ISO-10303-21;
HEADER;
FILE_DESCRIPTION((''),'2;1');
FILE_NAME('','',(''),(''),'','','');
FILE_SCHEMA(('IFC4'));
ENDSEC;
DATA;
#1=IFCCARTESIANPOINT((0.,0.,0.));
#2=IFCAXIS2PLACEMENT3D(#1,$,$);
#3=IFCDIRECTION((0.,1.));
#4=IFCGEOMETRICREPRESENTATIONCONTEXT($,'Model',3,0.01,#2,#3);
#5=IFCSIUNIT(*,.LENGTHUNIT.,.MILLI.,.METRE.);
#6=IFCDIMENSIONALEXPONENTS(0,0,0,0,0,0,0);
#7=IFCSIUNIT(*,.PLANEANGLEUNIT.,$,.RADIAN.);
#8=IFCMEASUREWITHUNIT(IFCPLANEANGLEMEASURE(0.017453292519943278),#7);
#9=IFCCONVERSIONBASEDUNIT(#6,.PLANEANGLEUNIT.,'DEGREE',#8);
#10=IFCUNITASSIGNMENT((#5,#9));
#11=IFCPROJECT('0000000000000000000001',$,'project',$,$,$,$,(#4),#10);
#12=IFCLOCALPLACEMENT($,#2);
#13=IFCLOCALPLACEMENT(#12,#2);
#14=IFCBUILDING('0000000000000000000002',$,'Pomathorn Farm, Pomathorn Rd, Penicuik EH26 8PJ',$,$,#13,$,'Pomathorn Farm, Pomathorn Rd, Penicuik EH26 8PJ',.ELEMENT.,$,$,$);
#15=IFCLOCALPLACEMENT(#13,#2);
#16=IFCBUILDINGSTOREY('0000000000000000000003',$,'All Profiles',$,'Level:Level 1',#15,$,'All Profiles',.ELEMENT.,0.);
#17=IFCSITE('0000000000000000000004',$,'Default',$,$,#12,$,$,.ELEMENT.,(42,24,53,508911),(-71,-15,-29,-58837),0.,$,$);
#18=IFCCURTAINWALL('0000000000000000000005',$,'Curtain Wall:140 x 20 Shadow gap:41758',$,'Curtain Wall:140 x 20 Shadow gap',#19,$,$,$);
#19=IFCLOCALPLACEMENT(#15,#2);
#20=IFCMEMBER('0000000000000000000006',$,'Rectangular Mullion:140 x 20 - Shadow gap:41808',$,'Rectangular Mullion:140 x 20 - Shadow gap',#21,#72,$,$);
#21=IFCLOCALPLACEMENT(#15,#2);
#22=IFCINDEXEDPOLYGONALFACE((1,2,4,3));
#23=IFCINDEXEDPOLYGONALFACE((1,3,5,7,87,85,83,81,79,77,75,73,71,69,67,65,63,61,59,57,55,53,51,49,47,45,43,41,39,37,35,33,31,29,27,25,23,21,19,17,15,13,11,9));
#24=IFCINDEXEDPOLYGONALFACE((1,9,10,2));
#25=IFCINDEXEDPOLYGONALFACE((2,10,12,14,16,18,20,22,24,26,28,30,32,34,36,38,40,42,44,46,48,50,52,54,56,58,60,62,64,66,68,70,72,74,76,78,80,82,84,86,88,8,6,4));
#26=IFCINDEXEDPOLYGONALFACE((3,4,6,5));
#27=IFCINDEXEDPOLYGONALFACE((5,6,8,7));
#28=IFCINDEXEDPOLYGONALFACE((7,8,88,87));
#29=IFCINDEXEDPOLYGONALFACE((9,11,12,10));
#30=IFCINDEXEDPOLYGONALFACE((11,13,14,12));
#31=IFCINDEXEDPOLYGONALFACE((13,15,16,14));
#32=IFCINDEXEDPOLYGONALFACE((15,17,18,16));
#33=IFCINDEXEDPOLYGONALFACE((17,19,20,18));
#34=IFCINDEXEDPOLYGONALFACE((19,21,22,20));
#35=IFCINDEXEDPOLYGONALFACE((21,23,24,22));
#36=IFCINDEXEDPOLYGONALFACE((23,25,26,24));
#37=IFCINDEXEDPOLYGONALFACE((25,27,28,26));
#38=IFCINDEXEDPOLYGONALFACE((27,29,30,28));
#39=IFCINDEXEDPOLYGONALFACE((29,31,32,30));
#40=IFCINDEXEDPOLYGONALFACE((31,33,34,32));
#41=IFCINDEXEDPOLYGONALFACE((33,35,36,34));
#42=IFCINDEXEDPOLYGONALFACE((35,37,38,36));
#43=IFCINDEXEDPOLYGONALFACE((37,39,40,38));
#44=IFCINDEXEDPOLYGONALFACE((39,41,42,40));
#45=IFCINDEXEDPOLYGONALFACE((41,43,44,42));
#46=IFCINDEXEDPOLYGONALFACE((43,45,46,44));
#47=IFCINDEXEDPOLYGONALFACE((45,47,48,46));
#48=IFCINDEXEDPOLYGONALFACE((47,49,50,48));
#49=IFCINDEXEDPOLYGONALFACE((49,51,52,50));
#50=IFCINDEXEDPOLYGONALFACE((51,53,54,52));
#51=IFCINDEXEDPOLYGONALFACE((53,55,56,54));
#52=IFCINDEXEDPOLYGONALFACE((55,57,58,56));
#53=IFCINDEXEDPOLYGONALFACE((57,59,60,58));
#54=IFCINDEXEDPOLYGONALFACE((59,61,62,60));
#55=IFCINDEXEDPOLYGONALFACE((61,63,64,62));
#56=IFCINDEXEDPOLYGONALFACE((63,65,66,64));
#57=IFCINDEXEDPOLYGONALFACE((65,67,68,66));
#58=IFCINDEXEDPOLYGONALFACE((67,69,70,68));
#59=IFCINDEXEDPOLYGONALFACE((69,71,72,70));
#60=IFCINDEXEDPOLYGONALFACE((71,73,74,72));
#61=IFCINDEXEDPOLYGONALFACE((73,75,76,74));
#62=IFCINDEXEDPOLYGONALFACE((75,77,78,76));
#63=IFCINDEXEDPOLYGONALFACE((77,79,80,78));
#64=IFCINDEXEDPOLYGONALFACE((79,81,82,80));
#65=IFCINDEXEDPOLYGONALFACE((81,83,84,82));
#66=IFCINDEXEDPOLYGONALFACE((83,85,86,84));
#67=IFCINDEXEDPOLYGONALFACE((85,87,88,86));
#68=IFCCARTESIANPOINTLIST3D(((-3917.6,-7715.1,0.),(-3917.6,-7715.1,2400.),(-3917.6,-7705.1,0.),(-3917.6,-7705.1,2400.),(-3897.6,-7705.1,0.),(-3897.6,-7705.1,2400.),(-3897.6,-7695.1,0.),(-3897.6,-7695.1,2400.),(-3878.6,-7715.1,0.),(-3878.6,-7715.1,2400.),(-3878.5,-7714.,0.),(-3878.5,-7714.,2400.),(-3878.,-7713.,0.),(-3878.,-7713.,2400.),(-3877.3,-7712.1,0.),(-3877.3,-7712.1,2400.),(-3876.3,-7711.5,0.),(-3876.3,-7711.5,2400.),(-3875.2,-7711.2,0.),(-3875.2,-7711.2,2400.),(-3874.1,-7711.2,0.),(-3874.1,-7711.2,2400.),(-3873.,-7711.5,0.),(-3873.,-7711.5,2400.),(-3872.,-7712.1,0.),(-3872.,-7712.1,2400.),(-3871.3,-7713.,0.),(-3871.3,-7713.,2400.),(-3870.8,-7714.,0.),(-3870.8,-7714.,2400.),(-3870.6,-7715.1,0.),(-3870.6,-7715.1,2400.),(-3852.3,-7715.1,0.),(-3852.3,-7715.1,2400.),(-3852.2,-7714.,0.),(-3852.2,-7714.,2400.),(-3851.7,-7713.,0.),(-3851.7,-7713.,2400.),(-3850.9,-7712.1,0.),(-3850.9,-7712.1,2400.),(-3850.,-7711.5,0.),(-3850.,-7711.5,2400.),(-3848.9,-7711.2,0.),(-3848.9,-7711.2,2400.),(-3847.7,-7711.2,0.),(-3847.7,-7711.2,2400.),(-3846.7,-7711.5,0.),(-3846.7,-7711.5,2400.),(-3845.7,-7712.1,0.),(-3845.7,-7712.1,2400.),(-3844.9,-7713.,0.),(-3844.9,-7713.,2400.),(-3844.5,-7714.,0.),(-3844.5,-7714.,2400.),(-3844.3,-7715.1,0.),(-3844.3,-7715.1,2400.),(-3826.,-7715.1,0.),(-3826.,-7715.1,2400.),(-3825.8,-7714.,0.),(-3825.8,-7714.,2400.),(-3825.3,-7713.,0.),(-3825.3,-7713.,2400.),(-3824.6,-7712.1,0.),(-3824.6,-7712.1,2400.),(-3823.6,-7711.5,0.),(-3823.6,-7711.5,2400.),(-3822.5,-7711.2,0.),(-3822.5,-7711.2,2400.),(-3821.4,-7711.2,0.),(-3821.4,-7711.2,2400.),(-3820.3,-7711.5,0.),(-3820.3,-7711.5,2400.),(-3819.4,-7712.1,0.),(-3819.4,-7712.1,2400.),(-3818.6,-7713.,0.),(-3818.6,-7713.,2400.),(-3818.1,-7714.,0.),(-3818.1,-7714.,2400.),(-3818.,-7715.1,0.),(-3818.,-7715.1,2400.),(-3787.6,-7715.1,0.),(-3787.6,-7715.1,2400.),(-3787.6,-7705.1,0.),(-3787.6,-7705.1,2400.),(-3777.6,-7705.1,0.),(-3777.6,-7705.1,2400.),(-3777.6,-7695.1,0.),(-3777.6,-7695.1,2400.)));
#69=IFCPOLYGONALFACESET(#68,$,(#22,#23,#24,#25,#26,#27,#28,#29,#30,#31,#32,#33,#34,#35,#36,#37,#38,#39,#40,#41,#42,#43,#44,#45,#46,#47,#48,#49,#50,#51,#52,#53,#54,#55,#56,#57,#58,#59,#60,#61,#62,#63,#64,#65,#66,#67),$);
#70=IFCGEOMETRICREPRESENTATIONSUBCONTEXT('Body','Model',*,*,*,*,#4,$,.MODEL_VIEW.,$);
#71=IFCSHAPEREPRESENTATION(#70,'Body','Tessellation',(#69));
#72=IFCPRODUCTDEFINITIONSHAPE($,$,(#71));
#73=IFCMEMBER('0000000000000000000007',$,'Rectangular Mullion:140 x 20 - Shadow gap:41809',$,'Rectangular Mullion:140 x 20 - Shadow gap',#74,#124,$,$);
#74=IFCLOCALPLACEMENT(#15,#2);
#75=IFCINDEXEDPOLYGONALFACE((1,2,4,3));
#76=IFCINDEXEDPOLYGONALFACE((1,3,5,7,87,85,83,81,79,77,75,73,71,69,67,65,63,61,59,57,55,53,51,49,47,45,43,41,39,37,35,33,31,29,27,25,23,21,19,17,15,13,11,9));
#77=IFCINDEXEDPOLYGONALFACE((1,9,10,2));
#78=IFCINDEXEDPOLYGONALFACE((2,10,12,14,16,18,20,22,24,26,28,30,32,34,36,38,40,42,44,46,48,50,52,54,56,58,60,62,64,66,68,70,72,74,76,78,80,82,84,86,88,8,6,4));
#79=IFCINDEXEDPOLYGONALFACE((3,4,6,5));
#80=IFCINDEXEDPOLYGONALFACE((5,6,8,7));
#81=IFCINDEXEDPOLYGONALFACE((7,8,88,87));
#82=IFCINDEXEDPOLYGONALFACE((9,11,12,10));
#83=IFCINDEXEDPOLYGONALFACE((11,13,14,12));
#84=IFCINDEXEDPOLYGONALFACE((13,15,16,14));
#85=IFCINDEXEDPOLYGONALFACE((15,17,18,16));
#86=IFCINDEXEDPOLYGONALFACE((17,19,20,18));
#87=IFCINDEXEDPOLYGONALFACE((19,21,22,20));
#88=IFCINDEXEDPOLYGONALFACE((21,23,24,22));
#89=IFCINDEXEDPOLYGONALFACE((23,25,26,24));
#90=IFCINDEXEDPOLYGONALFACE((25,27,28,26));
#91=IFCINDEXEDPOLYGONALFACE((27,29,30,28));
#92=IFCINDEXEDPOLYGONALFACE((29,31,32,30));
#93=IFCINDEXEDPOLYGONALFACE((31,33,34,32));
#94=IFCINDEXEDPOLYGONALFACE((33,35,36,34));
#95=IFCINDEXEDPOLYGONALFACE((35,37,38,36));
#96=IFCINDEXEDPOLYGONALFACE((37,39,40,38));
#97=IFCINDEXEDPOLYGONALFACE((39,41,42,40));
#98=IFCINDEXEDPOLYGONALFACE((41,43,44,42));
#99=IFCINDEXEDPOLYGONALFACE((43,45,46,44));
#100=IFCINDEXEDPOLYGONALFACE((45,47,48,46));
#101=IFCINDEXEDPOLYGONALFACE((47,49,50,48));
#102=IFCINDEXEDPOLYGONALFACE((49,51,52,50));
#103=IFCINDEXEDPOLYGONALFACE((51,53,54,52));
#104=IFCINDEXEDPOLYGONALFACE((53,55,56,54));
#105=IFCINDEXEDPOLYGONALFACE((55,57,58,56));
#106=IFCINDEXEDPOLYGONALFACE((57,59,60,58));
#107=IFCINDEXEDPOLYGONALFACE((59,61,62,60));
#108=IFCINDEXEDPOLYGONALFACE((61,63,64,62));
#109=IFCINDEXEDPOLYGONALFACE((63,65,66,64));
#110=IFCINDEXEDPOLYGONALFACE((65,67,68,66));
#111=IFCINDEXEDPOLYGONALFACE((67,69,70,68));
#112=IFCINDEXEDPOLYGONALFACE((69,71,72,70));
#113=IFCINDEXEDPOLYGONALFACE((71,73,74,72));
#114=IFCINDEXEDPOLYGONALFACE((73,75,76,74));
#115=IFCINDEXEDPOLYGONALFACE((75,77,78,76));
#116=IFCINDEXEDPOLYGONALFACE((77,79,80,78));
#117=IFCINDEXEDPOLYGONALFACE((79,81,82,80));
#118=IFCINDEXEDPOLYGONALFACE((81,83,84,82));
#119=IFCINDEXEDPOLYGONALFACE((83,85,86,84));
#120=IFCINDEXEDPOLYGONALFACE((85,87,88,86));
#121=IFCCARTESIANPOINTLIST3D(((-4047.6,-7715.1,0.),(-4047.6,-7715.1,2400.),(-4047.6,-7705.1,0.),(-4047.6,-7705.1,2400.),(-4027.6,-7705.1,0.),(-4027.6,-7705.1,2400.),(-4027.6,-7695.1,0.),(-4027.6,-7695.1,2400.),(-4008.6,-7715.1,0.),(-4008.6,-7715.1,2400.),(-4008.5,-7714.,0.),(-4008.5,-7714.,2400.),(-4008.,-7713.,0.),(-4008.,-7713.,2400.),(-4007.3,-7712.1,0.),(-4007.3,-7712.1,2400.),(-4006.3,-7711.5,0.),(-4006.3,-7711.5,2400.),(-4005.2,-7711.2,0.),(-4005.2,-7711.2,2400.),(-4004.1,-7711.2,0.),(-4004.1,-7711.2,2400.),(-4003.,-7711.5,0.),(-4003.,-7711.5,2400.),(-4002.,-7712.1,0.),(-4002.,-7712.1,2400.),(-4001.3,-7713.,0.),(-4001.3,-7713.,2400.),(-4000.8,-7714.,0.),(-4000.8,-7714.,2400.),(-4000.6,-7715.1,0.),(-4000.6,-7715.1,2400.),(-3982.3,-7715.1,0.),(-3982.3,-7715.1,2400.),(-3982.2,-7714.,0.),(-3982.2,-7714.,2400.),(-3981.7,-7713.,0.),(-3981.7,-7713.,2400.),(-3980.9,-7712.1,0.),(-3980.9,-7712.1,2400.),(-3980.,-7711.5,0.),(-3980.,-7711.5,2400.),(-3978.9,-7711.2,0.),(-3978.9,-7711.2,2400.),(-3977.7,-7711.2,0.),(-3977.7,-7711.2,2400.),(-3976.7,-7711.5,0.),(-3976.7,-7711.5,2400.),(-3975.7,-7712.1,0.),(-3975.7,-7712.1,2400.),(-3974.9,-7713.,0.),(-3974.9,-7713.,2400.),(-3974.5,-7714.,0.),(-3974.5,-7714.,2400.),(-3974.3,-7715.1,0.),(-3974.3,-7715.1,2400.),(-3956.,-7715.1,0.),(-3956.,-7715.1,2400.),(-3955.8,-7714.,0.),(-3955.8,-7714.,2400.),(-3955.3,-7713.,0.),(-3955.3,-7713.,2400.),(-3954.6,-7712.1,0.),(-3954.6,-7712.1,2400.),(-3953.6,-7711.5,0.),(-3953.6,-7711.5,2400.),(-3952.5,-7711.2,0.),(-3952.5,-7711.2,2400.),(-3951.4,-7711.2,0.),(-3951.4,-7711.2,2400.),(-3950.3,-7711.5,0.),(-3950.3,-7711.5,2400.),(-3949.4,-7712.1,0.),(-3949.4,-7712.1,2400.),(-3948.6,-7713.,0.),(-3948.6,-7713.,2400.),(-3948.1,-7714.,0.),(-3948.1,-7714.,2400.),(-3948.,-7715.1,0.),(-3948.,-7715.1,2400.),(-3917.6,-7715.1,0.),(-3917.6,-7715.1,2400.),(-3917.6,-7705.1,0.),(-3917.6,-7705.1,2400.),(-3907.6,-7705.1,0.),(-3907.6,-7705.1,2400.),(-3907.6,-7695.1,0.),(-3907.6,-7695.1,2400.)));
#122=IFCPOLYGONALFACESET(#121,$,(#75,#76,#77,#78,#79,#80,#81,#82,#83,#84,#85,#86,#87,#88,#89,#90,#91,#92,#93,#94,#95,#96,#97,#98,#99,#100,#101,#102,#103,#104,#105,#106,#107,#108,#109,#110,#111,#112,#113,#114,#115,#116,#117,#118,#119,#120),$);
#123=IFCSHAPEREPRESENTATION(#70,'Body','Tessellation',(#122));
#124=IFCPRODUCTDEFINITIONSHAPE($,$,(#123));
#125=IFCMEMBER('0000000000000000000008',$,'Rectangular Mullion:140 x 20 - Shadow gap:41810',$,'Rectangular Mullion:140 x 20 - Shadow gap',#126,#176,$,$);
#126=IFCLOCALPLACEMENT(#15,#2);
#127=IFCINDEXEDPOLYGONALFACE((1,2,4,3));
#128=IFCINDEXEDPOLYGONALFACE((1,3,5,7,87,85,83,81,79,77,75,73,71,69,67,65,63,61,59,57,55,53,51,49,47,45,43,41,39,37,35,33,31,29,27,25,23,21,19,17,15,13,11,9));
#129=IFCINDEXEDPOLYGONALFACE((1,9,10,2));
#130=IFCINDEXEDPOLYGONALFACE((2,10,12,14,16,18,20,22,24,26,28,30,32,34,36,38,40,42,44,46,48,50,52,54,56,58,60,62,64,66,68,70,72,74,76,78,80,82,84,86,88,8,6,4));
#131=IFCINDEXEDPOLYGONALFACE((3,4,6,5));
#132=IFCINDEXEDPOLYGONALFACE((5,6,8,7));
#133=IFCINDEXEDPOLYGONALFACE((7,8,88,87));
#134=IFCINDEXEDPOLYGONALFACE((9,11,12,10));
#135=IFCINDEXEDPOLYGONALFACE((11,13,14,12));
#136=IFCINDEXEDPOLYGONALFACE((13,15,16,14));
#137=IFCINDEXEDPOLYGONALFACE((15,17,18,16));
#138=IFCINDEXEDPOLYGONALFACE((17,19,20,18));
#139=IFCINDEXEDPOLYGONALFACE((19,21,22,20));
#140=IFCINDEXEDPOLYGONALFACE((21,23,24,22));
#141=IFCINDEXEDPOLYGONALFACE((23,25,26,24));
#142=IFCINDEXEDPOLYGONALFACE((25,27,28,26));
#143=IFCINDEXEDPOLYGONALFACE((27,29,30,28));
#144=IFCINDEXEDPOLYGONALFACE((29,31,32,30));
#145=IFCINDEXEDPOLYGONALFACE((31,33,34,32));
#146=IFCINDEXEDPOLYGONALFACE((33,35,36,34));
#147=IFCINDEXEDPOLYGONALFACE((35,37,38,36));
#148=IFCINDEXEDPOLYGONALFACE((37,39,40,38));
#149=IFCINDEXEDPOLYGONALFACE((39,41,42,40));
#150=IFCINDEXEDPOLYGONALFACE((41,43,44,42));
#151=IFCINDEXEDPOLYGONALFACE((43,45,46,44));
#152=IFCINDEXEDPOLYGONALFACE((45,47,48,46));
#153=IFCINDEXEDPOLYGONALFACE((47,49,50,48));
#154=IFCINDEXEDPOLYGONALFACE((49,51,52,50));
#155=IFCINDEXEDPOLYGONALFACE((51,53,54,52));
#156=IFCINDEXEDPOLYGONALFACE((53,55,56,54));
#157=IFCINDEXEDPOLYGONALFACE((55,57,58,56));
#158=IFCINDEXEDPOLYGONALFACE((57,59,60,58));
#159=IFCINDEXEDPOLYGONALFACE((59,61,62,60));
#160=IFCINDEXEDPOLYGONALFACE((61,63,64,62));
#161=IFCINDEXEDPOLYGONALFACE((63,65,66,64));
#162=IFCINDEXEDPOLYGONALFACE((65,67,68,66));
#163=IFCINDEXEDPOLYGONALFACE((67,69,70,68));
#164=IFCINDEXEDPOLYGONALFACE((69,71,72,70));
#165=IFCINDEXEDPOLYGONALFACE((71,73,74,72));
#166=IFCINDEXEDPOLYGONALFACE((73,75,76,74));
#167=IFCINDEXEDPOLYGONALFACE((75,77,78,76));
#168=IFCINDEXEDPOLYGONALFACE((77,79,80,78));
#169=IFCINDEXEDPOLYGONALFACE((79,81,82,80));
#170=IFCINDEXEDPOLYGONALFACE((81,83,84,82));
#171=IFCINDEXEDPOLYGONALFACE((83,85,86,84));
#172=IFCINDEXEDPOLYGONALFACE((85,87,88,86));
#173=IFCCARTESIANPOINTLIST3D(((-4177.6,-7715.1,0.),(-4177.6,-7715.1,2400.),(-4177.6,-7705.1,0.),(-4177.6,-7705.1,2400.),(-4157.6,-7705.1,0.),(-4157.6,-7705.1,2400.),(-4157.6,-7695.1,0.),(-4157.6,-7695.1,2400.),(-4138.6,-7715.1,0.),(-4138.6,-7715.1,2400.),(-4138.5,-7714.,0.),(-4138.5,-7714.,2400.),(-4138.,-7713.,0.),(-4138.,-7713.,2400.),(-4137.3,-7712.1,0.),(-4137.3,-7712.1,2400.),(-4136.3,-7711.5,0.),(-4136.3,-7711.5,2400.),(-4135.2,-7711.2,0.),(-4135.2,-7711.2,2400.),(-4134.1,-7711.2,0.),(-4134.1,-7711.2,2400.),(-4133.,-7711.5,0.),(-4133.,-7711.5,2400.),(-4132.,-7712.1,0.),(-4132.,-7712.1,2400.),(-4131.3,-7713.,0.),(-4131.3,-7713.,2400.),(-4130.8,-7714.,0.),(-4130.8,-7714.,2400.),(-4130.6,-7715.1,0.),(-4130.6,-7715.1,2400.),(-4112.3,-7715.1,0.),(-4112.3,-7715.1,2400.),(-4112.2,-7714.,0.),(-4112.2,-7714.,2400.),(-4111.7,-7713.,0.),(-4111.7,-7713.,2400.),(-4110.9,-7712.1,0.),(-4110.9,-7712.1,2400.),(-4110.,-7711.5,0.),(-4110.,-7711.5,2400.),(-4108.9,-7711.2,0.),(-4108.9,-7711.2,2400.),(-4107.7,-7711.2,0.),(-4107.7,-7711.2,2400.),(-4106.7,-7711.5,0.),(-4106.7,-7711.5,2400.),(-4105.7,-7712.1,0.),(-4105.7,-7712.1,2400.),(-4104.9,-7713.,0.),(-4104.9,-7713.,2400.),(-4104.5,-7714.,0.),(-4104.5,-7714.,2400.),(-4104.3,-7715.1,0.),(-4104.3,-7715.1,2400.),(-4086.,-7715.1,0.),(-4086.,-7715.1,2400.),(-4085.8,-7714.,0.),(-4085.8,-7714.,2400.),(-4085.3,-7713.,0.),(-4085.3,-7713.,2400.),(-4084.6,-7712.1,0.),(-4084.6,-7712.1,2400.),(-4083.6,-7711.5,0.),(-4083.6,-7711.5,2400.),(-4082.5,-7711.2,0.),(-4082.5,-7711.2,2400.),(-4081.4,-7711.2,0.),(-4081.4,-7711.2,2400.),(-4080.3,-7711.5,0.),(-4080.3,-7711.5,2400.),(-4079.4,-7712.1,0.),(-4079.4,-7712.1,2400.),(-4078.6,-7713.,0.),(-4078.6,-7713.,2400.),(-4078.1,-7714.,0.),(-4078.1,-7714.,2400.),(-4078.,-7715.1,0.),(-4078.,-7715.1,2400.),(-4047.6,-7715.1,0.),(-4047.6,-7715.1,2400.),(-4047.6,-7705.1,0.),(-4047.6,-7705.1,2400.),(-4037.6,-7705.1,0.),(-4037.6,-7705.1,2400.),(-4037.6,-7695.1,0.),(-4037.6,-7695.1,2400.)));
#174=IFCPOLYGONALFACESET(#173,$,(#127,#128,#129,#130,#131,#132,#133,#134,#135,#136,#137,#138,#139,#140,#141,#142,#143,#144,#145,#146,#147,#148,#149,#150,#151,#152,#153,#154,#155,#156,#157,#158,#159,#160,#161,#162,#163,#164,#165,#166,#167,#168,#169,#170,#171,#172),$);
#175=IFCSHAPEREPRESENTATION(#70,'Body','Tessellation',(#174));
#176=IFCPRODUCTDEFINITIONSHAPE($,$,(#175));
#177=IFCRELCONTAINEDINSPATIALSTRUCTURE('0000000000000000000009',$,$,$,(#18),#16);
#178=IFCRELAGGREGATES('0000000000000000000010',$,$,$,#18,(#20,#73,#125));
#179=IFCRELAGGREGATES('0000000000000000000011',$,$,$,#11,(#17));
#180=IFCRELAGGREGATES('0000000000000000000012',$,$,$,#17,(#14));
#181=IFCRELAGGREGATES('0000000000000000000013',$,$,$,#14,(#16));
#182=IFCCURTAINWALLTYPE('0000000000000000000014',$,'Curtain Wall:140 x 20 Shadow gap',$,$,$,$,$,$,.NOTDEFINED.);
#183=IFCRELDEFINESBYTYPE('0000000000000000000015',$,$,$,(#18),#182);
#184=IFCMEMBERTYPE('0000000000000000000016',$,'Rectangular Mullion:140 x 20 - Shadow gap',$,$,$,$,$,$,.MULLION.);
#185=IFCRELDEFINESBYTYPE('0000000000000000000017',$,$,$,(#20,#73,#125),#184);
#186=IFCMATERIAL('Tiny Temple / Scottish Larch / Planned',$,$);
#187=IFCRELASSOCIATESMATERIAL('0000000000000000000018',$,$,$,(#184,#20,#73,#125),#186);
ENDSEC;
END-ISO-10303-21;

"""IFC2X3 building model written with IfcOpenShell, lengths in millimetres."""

from ifc_helpers import new_model, entity, si_unit, converted_unit, direction, frame, frame_2d, origin, place, context, subcontext, project, spatial, polyline, circle_curve, parameter, trimmed, segment, composite_curve, outline, extrude, source, transform, mapped, material, type_object, type_shapes, element, aggregate, save


model = new_model("IFC2X3")

# Units and contexts
model_context = context("Model", 3, precision=0.01, world=origin(), true_north=direction((0.0, 1.0)))
body_context = subcontext(model_context, "Body", "Model", "MODEL_VIEW")
ifc_project = project(units=[si_unit("LENGTHUNIT", "METRE", prefix="MILLI"), converted_unit("PLANEANGLEUNIT", "DEGREE", entity("IfcPlaneAngleMeasure", 0.017453292519943278), si_unit("PLANEANGLEUNIT", "RADIAN"), dimensions=[0, 0, 0, 0, 0, 0, 0])], contexts=[model_context])

# Site, building, storey
site_placement = place(None, origin())
site = spatial("IfcSite", under=ifc_project, at=site_placement, Name="Default", CompositionType="ELEMENT", RefLatitude=(42, 24, 53, 508911), RefLongitude=(-71, -15, -29, -58837), RefElevation=0.0)
building_placement = place(site_placement, origin())
building = spatial("IfcBuilding", under=site, at=building_placement, Name="Pomathorn Farm, Pomathorn Rd, Penicuik EH26 8PJ", LongName="Pomathorn Farm, Pomathorn Rd, Penicuik EH26 8PJ", CompositionType="ELEMENT")
storey_placement = place(building_placement, origin())
storey = spatial("IfcBuildingStorey", under=building, at=storey_placement, Name="All Profiles", ObjectType="Level:Level 1", LongName="All Profiles", CompositionType="ELEMENT", Elevation=0.0)

# Curtain wall, members
ifc_material = material(Name="Tiny Temple / Scottish Larch / Planned")
curtain_wall_type_1 = type_object("IfcCurtainWallType", Name="Curtain Wall:140 x 20 Shadow gap", PredefinedType="NOTDEFINED")
curtain_wall_1_placement = place(storey_placement, origin())
curtain_wall_1 = element("IfcCurtainWall", 1, at=curtain_wall_1_placement, inside=storey, type_object=curtain_wall_type_1, Name="Curtain Wall:140 x 20 Shadow gap:41758", ObjectType="Curtain Wall:140 x 20 Shadow gap")
member_type_1 = type_object("IfcMemberType", Name="Rectangular Mullion:140 x 20 - Shadow gap", PredefinedType="MULLION", material=ifc_material)
shared_shape_1 = source(origin(), body_context, "Body", "SweptSolid", [
    extrude(outline(composite_curve([segment(polyline([(28.5, -5.7), (58.9, -5.7)]), True, "CONTINUOUS"), segment(polyline([(58.9, -5.7), (58.9, 4.3)]), True, "CONTINUOUS"), segment(polyline([(58.9, 4.3), (68.9, 4.3)]), True, "CONTINUOUS"), segment(polyline([(68.9, 4.3), (68.9, 14.3)]), True, "CONTINUOUS"), segment(polyline([(68.9, 14.3), (-51.1, 14.3)]), True, "CONTINUOUS"), segment(polyline([(-51.1, 14.3), (-51.1, 4.3)]), True, "CONTINUOUS"), segment(polyline([(-51.1, 4.3), (-71.1, 4.3)]), True, "CONTINUOUS"), segment(polyline([(-71.1, 4.3), (-71.1, -5.7)]), True, "CONTINUOUS"), segment(polyline([(-71.1, -5.7), (-32.1, -5.7)]), True, "CONTINUOUS"), segment(trimmed(circle_curve(frame_2d((-28.1, -5.7), x_axis=(1.0, 0.0)), 4.0), [parameter(360.0)], [parameter(180.0)], True, "PARAMETER"), False, "CONTINUOUS"), segment(polyline([(-24.1, -5.7), (-5.8, -5.7)]), True, "CONTINUOUS"), segment(trimmed(circle_curve(frame_2d((-1.8, -5.7), x_axis=(1.0, 0.0)), 4.0), [parameter(360.0)], [parameter(180.0)], True, "PARAMETER"), False, "CONTINUOUS"), segment(polyline([(2.2, -5.7), (20.5, -5.7)]), True, "CONTINUOUS"), segment(trimmed(circle_curve(frame_2d((24.5, -5.7), x_axis=(1.0, 0.0)), 4.0), [parameter(360.0)], [parameter(180.0)], True, "PARAMETER"), False, "CONTINUOUS")], self_intersect=False)), frame((-68.9, -5.7, -2400.0), z_axis=(0.0, 0.0, -1.0), x_axis=(1.0, 0.0, 0.0)), (0.0, 0.0, -1.0), 2400.0),
])
type_shapes(member_type_1, [shared_shape_1])
member_1_placement = place(curtain_wall_1_placement, frame((-3777.6, -7715.1, 0.0), z_axis=(0.0, 0.0, -1.0), x_axis=(1.0, 0.0, 0.0)))
member_1 = element("IfcMember", 2, at=member_1_placement, type_object=member_type_1, material=ifc_material, Name="Rectangular Mullion:140 x 20 - Shadow gap:41808", ObjectType="Rectangular Mullion:140 x 20 - Shadow gap", context=body_context, shape_type="MappedRepresentation", body=[
    mapped(shared_shape_1, transform((0.0, 0.0, 0.0), scale=1.0)),
])
member_2_placement = place(curtain_wall_1_placement, frame((-3907.6, -7715.1, 0.0), z_axis=(0.0, 0.0, -1.0), x_axis=(1.0, 0.0, 0.0)))
member_2 = element("IfcMember", 3, at=member_2_placement, type_object=member_type_1, material=ifc_material, Name="Rectangular Mullion:140 x 20 - Shadow gap:41809", ObjectType="Rectangular Mullion:140 x 20 - Shadow gap", context=body_context, shape_type="MappedRepresentation", body=[
    mapped(shared_shape_1, transform((0.0, 0.0, 0.0), scale=1.0)),
])
member_3_placement = place(curtain_wall_1_placement, frame((-4037.6, -7715.1, 0.0), z_axis=(0.0, 0.0, -1.0), x_axis=(1.0, 0.0, 0.0)))
member_3 = element("IfcMember", 4, at=member_3_placement, type_object=member_type_1, material=ifc_material, Name="Rectangular Mullion:140 x 20 - Shadow gap:41810", ObjectType="Rectangular Mullion:140 x 20 - Shadow gap", context=body_context, shape_type="MappedRepresentation", body=[
    mapped(shared_shape_1, transform((0.0, 0.0, 0.0), scale=1.0)),
])
aggregate(curtain_wall_1, [member_1, member_2, member_3])

save(model, "model.ifc")
